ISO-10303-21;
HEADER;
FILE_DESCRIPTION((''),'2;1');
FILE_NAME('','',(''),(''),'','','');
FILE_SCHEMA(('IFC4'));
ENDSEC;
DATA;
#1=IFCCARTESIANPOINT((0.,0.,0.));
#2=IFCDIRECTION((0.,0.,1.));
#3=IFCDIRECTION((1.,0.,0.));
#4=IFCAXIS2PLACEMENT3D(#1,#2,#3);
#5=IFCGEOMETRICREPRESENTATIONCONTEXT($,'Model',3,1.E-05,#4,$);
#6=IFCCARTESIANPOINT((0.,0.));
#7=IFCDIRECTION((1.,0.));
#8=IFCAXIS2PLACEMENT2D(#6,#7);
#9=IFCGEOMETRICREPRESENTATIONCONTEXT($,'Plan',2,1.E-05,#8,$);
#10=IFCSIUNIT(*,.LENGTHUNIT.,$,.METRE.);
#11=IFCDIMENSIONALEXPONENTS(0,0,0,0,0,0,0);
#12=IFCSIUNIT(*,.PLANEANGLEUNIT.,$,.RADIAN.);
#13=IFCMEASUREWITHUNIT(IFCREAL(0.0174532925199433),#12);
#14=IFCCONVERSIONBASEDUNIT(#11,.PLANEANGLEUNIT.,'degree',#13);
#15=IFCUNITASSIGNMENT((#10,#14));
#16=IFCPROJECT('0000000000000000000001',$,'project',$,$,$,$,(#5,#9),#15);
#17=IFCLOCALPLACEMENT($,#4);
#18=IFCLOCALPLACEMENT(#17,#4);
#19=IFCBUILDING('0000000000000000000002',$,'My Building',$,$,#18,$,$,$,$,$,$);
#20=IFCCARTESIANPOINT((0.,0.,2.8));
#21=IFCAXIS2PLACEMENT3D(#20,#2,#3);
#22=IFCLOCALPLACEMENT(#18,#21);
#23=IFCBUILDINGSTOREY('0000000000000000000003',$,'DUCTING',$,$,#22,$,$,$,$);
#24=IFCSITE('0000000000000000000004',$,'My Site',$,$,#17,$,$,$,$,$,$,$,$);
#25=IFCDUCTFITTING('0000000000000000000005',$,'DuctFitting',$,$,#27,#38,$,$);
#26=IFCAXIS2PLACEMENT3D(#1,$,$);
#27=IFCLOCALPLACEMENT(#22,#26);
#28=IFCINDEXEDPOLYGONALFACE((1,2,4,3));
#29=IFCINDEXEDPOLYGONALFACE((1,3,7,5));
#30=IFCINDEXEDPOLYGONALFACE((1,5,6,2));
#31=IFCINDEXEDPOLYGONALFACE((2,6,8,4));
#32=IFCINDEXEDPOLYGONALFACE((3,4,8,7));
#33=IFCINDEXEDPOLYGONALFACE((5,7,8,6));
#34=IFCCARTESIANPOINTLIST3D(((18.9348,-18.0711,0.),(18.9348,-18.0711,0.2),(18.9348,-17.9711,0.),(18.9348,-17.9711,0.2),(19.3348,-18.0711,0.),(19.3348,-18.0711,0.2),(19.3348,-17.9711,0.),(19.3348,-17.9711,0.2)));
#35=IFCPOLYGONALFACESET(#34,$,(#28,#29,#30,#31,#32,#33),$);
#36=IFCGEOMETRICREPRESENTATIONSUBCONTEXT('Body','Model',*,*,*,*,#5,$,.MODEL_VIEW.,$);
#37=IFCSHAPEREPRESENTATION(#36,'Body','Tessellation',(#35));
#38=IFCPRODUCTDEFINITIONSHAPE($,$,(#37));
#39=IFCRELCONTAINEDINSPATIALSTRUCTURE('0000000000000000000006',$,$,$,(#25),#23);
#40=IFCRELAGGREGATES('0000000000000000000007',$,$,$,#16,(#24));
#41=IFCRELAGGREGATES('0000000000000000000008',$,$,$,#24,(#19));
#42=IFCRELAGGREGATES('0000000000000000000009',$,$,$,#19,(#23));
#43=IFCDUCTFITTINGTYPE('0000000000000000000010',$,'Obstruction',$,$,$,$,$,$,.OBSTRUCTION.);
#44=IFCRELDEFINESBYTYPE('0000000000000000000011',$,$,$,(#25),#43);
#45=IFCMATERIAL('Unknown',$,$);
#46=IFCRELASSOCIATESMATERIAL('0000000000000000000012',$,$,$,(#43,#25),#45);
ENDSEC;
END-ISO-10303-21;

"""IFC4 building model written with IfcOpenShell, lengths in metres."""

from ifc_helpers import new_model, entity, si_unit, converted_unit, frame, origin_with_axes, origin_2d_with_axis, place, context, subcontext, project, spatial, rectangle, extrude, material, material_profile, profile_set, profile_usage, type_object, element, save


model = new_model("IFC4")

# Units and contexts
model_context = context("Model", 3, precision=1e-05, world=origin_with_axes())
plan_context = context("Plan", 2, precision=1e-05, world=origin_2d_with_axis())
body_context = subcontext(model_context, "Body", "Model", "MODEL_VIEW")
ifc_project = project(units=[si_unit("LENGTHUNIT", "METRE"), converted_unit("PLANEANGLEUNIT", "degree", entity("IfcReal", 0.0174532925199433), si_unit("PLANEANGLEUNIT", "RADIAN"), dimensions=[0, 0, 0, 0, 0, 0, 0])], contexts=[model_context, plan_context])

# Site, building, storey
site_placement = place(None, origin_with_axes())
site = spatial("IfcSite", under=ifc_project, at=site_placement, Name="My Site")
building_placement = place(site_placement, origin_with_axes())
building = spatial("IfcBuilding", under=site, at=building_placement, Name="My Building")
storey_placement = place(building_placement, frame((0.0, 0.0, 2.8), z_axis=(0.0, 0.0, 1.0), x_axis=(1.0, 0.0, 0.0)))
storey = spatial("IfcBuildingStorey", under=building, at=storey_placement, Name="DUCTING")

# Shared definitions
ifc_material = material(Name="Unknown")

# Duct fitting
ifc_material_profile_1 = material_profile(ifc_material, rectangle(XDim=0.4, YDim=0.2))
ifc_profile_set_1 = profile_set([ifc_material_profile_1])
duct_fitting_type_1 = type_object("IfcDuctFittingType", Name="Obstruction", PredefinedType="OBSTRUCTION", material=ifc_profile_set_1)
ifc_profile_usage_1 = profile_usage(ifc_profile_set_1, cardinal=5)
duct_fitting_1_placement = place(storey_placement, frame((19.1348, -17.9711, 0.1), z_axis=(0.0, -1.0, 0.0), x_axis=(1.0, 0.0, 0.0)))
element("IfcDuctFitting", 1, at=duct_fitting_1_placement, inside=storey, type_object=duct_fitting_type_1, material=ifc_profile_usage_1, Name="DuctFitting", context=body_context, shape_type="SweptSolid", body=[
    extrude(rectangle(XDim=0.4, YDim=0.2), origin_with_axes(), (0.0, 0.0, 1.0), 0.1),
])

save(model, "model.ifc")
